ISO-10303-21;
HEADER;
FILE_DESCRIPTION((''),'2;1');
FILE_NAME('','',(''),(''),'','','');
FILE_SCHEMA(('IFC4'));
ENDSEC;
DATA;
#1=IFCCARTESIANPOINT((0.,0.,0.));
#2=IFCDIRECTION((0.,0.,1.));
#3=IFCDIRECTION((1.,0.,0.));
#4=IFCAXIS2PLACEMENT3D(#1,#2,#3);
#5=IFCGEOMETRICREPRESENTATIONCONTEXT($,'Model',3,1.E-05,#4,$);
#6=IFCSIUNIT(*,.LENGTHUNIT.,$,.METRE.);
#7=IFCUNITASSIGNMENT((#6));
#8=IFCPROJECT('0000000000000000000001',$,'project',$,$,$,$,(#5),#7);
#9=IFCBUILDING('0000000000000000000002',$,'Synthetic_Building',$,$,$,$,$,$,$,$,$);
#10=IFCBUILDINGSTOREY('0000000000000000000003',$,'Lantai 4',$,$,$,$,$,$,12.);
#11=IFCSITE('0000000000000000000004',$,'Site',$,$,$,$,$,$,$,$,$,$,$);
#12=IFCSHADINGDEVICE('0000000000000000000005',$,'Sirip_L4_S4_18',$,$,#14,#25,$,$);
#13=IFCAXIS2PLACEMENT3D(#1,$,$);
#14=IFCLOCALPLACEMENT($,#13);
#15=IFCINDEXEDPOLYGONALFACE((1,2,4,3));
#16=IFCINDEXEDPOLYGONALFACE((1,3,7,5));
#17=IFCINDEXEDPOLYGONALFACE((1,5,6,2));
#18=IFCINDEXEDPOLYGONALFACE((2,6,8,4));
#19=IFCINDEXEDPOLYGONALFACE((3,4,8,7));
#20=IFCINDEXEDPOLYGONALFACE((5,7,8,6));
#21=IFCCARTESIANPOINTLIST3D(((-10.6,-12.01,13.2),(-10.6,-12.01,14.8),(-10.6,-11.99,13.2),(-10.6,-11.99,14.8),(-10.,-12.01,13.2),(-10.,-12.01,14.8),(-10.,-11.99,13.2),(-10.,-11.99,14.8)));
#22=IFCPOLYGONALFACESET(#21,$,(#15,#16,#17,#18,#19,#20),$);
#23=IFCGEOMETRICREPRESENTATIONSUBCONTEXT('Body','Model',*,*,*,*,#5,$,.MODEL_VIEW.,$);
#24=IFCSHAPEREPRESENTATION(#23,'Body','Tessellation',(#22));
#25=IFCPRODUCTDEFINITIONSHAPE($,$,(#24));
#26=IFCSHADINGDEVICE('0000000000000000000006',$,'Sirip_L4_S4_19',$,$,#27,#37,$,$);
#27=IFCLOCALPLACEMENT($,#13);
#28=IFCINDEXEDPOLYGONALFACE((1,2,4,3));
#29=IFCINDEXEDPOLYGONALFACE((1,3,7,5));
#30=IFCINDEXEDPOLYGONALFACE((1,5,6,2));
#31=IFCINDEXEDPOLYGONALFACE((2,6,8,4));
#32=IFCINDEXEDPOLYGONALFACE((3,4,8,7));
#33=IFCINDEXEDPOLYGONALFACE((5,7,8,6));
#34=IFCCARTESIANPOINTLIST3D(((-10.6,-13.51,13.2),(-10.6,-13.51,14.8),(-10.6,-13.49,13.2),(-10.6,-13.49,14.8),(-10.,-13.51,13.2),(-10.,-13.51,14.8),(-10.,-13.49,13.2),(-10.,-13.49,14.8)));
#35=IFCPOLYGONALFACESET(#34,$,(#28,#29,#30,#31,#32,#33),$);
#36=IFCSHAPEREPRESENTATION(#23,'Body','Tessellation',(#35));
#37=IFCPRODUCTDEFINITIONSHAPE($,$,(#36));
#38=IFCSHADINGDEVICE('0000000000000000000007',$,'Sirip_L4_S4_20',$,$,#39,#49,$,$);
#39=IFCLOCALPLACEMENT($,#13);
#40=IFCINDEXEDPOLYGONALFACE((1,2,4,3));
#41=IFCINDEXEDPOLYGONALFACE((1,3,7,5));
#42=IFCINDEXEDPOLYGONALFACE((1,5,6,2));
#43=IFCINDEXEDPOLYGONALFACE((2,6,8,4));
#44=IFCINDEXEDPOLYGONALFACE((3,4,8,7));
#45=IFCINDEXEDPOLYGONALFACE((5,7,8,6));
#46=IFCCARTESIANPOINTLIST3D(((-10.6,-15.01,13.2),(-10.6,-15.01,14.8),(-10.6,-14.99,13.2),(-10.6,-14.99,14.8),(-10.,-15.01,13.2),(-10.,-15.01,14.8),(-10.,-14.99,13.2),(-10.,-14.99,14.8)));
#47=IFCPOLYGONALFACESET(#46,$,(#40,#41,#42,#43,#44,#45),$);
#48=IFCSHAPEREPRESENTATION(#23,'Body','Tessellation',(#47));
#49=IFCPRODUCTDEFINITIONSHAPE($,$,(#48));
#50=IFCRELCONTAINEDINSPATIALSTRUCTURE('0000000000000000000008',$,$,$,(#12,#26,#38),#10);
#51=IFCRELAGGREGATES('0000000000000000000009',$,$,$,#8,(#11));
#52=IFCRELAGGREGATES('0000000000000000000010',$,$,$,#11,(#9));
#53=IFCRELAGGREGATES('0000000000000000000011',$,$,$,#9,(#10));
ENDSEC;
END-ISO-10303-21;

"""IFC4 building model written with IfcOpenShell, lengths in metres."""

from ifc_helpers import new_model, si_unit, frame, origin_with_axes, place, context, subcontext, project, spatial, polyline, outline, extrude, element, save


model = new_model("IFC4")

# Units and contexts
model_context = context("Model", 3, precision=1e-05, world=origin_with_axes())
body_context = subcontext(model_context, "Body", "Model", "MODEL_VIEW")
ifc_project = project(units=[si_unit("LENGTHUNIT", "METRE")], contexts=[model_context])

# Site, building, storey
site = spatial("IfcSite", under=ifc_project, Name="Site")
building = spatial("IfcBuilding", under=site, Name="Synthetic_Building")
storey = spatial("IfcBuildingStorey", under=building, Name="Lantai 4", Elevation=12.0)

# Shading devices
shading_device_1_placement = place(None, origin_with_axes())
element("IfcShadingDevice", 1, at=shading_device_1_placement, inside=storey, Name="Sirip_L4_S4_18", context=body_context, shape_type="SweptSolid", body=[
    extrude(outline(polyline([(-10.0, -11.99), (-10.0, -12.01), (-10.6, -12.01), (-10.6, -11.99), (-10.0, -11.99)])), frame((0.0, 0.0, 13.2), z_axis=(0.0, 0.0, 1.0), x_axis=(1.0, 0.0, 0.0)), (0.0, 0.0, 1.0), 1.6),
])
shading_device_2_placement = place(None, origin_with_axes())
element("IfcShadingDevice", 2, at=shading_device_2_placement, inside=storey, Name="Sirip_L4_S4_19", context=body_context, shape_type="SweptSolid", body=[
    extrude(outline(polyline([(-10.0, -13.49), (-10.0, -13.51), (-10.6, -13.51), (-10.6, -13.49), (-10.0, -13.49)])), frame((0.0, 0.0, 13.2), z_axis=(0.0, 0.0, 1.0), x_axis=(1.0, 0.0, 0.0)), (0.0, 0.0, 1.0), 1.6),
])
shading_device_3_placement = place(None, origin_with_axes())
element("IfcShadingDevice", 3, at=shading_device_3_placement, inside=storey, Name="Sirip_L4_S4_20", context=body_context, shape_type="SweptSolid", body=[
    extrude(outline(polyline([(-10.0, -14.99), (-10.0, -15.01), (-10.6, -15.01), (-10.6, -14.99), (-10.0, -14.99)])), frame((0.0, 0.0, 13.2), z_axis=(0.0, 0.0, 1.0), x_axis=(1.0, 0.0, 0.0)), (0.0, 0.0, 1.0), 1.6),
])

save(model, "model.ifc")
